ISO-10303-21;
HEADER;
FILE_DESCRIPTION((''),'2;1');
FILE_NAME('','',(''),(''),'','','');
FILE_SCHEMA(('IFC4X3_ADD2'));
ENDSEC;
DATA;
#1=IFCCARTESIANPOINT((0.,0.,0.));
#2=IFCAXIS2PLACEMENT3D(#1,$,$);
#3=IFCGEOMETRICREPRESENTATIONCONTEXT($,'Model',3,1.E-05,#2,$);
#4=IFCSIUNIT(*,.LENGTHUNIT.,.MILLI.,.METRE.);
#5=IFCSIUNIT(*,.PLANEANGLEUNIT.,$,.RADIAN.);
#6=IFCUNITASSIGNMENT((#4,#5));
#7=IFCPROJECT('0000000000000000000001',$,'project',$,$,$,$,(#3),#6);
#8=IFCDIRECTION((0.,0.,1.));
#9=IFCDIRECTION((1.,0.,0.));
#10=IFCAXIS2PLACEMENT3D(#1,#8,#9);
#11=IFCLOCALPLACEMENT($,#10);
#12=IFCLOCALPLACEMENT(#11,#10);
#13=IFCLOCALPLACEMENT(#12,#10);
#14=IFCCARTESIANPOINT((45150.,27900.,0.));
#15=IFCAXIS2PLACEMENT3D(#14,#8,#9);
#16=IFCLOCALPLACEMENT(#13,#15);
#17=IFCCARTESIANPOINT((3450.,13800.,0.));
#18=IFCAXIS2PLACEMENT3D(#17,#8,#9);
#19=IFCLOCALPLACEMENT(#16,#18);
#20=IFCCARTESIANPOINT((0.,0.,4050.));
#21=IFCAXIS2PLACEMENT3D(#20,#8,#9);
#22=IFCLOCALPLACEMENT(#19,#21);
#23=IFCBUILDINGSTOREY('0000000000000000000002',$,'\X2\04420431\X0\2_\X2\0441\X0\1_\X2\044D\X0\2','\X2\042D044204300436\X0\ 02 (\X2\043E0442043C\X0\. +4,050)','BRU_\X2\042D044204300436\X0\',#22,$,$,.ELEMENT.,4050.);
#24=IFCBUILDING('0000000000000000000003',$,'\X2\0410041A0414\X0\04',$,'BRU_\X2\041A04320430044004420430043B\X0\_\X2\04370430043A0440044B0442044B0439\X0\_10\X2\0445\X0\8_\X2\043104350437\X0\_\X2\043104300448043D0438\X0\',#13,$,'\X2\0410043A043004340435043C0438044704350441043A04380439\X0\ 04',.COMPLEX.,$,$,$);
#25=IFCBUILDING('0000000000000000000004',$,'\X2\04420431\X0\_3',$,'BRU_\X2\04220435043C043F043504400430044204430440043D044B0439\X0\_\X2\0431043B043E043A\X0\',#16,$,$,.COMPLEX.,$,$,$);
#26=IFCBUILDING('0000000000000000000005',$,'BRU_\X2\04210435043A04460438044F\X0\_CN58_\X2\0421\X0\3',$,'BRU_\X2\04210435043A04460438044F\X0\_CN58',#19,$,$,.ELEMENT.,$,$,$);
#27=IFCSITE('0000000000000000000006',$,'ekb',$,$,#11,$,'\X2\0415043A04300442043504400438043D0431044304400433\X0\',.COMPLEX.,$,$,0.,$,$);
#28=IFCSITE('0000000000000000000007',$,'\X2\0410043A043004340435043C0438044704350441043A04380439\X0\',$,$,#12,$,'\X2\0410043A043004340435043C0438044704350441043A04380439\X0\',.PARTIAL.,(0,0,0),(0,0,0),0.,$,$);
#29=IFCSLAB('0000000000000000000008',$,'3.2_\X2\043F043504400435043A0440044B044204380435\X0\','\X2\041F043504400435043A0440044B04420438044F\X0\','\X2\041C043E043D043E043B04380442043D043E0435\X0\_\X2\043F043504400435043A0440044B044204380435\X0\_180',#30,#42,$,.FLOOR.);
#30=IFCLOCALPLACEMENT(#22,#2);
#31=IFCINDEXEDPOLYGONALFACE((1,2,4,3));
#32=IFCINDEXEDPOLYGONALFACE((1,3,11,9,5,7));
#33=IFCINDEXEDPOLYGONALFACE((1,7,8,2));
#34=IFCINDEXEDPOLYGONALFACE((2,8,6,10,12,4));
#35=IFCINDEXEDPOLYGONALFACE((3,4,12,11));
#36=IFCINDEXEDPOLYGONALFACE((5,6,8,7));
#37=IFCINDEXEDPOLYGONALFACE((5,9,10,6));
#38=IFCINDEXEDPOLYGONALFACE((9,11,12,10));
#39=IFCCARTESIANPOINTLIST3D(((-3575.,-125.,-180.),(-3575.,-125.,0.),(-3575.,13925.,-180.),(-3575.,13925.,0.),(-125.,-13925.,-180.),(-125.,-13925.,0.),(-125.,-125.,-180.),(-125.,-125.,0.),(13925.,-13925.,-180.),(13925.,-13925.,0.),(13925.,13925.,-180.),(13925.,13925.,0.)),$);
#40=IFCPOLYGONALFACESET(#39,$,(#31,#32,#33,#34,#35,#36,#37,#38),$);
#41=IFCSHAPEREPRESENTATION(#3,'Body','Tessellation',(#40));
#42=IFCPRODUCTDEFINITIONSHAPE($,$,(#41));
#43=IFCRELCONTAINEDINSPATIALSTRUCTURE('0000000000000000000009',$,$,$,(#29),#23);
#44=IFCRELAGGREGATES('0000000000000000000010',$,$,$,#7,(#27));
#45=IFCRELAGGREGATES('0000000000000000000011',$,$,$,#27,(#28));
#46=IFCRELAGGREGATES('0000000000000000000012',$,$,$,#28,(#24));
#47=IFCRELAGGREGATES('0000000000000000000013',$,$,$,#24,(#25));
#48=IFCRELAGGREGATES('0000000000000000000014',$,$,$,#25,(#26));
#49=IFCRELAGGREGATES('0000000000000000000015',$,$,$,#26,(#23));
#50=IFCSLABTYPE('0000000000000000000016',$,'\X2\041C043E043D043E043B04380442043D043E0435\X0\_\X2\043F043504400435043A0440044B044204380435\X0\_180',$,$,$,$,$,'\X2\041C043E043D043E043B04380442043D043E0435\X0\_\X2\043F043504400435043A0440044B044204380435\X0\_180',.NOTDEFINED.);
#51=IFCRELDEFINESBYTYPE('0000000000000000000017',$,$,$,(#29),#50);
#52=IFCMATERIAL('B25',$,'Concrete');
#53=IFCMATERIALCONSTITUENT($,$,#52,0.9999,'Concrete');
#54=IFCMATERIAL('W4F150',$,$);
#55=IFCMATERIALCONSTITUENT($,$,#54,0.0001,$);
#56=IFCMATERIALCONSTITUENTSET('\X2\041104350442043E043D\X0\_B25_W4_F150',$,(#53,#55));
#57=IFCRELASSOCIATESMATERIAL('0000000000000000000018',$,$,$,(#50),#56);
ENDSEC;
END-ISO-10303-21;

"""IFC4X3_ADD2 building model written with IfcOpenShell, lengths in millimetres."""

from ifc_helpers import new_model, si_unit, frame, origin, origin_with_axes, place, context, project, spatial, polyline, outline, extrude, material, constituent, constituent_set, type_object, element, save


model = new_model("IFC4X3_ADD2")

# Units and contexts
model_context = context("Model", 3, precision=1e-05, world=origin())
ifc_project = project(units=[si_unit("LENGTHUNIT", "METRE", prefix="MILLI"), si_unit("PLANEANGLEUNIT", "RADIAN")], contexts=[model_context])

# Sites, buildings, storey
site_1_placement = place(None, origin_with_axes())
site_1 = spatial("IfcSite", under=ifc_project, at=site_1_placement, Name="ekb", LongName="Екатеринбург", CompositionType="COMPLEX", RefElevation=0.0)
site_2_placement = place(site_1_placement, origin_with_axes())
site_2 = spatial("IfcSite", under=site_1, at=site_2_placement, Name="Академический", LongName="Академический", CompositionType="PARTIAL", RefLatitude=(0, 0, 0), RefLongitude=(0, 0, 0), RefElevation=0.0)
building_1_placement = place(site_2_placement, origin_with_axes())
building_1 = spatial("IfcBuilding", under=site_2, at=building_1_placement, Name="АКД04", ObjectType="BRU_Квартал_закрытый_10х8_без_башни", LongName="Академический 04", CompositionType="COMPLEX")
building_2_placement = place(building_1_placement, frame((45150.0, 27900.0, 0.0), z_axis=(0.0, 0.0, 1.0), x_axis=(1.0, 0.0, 0.0)))
building_2 = spatial("IfcBuilding", under=building_1, at=building_2_placement, Name="тб_3", ObjectType="BRU_Температурный_блок", CompositionType="COMPLEX")
building_3_placement = place(building_2_placement, frame((3450.0, 13800.0, 0.0), z_axis=(0.0, 0.0, 1.0), x_axis=(1.0, 0.0, 0.0)))
building_3 = spatial("IfcBuilding", under=building_2, at=building_3_placement, Name="BRU_Секция_CN58_С3", ObjectType="BRU_Секция_CN58", CompositionType="ELEMENT")
storey_placement = place(building_3_placement, frame((0.0, 0.0, 4050.0), z_axis=(0.0, 0.0, 1.0), x_axis=(1.0, 0.0, 0.0)))
storey = spatial("IfcBuildingStorey", under=building_3, at=storey_placement, Name="тб2_с1_э2", Description="Этаж 02 (отм. +4,050)", ObjectType="BRU_Этаж", CompositionType="ELEMENT", Elevation=4050.0)

# Shared definitions
ifc_material_1 = material(Name="B25", Category="Concrete")
ifc_material_2 = material(Name="W4F150")

# Slab
ifc_constituent_1 = constituent(ifc_material_1, Category="Concrete", fraction=0.9999)
ifc_constituent_2 = constituent(ifc_material_2, fraction=0.0001)
ifc_constituent_set_1 = constituent_set(constituents=[ifc_constituent_1, ifc_constituent_2], Name="Бетон_B25_W4_F150")
slab_type = type_object("IfcSlabType", Name="Монолитное_перекрытие_180", ElementType="Монолитное_перекрытие_180", PredefinedType="NOTDEFINED", material=ifc_constituent_set_1)
slab_placement = place(storey_placement, frame((0.0, 0.0, -180.0), z_axis=(0.0, 0.0, 1.0), x_axis=(1.0, 0.0, 0.0)))
element("IfcSlab", 1, at=slab_placement, inside=storey, type_object=slab_type, Name="3.2_перекрытие", Description="Перекрытия", ObjectType="Монолитное_перекрытие_180", PredefinedType="FLOOR", context=model_context, shape_type="SweptSolid", body=[
    extrude(outline(polyline([(-125.0, -13925.0), (13925.0, -13925.0), (13925.0, 13925.0), (-3575.0, 13925.0), (-3575.0, -125.0), (-125.0, -125.0), (-125.0, -13925.0)])), origin_with_axes(), (0.0, 0.0, 1.0), 180.0),
])

save(model, "model.ifc")
